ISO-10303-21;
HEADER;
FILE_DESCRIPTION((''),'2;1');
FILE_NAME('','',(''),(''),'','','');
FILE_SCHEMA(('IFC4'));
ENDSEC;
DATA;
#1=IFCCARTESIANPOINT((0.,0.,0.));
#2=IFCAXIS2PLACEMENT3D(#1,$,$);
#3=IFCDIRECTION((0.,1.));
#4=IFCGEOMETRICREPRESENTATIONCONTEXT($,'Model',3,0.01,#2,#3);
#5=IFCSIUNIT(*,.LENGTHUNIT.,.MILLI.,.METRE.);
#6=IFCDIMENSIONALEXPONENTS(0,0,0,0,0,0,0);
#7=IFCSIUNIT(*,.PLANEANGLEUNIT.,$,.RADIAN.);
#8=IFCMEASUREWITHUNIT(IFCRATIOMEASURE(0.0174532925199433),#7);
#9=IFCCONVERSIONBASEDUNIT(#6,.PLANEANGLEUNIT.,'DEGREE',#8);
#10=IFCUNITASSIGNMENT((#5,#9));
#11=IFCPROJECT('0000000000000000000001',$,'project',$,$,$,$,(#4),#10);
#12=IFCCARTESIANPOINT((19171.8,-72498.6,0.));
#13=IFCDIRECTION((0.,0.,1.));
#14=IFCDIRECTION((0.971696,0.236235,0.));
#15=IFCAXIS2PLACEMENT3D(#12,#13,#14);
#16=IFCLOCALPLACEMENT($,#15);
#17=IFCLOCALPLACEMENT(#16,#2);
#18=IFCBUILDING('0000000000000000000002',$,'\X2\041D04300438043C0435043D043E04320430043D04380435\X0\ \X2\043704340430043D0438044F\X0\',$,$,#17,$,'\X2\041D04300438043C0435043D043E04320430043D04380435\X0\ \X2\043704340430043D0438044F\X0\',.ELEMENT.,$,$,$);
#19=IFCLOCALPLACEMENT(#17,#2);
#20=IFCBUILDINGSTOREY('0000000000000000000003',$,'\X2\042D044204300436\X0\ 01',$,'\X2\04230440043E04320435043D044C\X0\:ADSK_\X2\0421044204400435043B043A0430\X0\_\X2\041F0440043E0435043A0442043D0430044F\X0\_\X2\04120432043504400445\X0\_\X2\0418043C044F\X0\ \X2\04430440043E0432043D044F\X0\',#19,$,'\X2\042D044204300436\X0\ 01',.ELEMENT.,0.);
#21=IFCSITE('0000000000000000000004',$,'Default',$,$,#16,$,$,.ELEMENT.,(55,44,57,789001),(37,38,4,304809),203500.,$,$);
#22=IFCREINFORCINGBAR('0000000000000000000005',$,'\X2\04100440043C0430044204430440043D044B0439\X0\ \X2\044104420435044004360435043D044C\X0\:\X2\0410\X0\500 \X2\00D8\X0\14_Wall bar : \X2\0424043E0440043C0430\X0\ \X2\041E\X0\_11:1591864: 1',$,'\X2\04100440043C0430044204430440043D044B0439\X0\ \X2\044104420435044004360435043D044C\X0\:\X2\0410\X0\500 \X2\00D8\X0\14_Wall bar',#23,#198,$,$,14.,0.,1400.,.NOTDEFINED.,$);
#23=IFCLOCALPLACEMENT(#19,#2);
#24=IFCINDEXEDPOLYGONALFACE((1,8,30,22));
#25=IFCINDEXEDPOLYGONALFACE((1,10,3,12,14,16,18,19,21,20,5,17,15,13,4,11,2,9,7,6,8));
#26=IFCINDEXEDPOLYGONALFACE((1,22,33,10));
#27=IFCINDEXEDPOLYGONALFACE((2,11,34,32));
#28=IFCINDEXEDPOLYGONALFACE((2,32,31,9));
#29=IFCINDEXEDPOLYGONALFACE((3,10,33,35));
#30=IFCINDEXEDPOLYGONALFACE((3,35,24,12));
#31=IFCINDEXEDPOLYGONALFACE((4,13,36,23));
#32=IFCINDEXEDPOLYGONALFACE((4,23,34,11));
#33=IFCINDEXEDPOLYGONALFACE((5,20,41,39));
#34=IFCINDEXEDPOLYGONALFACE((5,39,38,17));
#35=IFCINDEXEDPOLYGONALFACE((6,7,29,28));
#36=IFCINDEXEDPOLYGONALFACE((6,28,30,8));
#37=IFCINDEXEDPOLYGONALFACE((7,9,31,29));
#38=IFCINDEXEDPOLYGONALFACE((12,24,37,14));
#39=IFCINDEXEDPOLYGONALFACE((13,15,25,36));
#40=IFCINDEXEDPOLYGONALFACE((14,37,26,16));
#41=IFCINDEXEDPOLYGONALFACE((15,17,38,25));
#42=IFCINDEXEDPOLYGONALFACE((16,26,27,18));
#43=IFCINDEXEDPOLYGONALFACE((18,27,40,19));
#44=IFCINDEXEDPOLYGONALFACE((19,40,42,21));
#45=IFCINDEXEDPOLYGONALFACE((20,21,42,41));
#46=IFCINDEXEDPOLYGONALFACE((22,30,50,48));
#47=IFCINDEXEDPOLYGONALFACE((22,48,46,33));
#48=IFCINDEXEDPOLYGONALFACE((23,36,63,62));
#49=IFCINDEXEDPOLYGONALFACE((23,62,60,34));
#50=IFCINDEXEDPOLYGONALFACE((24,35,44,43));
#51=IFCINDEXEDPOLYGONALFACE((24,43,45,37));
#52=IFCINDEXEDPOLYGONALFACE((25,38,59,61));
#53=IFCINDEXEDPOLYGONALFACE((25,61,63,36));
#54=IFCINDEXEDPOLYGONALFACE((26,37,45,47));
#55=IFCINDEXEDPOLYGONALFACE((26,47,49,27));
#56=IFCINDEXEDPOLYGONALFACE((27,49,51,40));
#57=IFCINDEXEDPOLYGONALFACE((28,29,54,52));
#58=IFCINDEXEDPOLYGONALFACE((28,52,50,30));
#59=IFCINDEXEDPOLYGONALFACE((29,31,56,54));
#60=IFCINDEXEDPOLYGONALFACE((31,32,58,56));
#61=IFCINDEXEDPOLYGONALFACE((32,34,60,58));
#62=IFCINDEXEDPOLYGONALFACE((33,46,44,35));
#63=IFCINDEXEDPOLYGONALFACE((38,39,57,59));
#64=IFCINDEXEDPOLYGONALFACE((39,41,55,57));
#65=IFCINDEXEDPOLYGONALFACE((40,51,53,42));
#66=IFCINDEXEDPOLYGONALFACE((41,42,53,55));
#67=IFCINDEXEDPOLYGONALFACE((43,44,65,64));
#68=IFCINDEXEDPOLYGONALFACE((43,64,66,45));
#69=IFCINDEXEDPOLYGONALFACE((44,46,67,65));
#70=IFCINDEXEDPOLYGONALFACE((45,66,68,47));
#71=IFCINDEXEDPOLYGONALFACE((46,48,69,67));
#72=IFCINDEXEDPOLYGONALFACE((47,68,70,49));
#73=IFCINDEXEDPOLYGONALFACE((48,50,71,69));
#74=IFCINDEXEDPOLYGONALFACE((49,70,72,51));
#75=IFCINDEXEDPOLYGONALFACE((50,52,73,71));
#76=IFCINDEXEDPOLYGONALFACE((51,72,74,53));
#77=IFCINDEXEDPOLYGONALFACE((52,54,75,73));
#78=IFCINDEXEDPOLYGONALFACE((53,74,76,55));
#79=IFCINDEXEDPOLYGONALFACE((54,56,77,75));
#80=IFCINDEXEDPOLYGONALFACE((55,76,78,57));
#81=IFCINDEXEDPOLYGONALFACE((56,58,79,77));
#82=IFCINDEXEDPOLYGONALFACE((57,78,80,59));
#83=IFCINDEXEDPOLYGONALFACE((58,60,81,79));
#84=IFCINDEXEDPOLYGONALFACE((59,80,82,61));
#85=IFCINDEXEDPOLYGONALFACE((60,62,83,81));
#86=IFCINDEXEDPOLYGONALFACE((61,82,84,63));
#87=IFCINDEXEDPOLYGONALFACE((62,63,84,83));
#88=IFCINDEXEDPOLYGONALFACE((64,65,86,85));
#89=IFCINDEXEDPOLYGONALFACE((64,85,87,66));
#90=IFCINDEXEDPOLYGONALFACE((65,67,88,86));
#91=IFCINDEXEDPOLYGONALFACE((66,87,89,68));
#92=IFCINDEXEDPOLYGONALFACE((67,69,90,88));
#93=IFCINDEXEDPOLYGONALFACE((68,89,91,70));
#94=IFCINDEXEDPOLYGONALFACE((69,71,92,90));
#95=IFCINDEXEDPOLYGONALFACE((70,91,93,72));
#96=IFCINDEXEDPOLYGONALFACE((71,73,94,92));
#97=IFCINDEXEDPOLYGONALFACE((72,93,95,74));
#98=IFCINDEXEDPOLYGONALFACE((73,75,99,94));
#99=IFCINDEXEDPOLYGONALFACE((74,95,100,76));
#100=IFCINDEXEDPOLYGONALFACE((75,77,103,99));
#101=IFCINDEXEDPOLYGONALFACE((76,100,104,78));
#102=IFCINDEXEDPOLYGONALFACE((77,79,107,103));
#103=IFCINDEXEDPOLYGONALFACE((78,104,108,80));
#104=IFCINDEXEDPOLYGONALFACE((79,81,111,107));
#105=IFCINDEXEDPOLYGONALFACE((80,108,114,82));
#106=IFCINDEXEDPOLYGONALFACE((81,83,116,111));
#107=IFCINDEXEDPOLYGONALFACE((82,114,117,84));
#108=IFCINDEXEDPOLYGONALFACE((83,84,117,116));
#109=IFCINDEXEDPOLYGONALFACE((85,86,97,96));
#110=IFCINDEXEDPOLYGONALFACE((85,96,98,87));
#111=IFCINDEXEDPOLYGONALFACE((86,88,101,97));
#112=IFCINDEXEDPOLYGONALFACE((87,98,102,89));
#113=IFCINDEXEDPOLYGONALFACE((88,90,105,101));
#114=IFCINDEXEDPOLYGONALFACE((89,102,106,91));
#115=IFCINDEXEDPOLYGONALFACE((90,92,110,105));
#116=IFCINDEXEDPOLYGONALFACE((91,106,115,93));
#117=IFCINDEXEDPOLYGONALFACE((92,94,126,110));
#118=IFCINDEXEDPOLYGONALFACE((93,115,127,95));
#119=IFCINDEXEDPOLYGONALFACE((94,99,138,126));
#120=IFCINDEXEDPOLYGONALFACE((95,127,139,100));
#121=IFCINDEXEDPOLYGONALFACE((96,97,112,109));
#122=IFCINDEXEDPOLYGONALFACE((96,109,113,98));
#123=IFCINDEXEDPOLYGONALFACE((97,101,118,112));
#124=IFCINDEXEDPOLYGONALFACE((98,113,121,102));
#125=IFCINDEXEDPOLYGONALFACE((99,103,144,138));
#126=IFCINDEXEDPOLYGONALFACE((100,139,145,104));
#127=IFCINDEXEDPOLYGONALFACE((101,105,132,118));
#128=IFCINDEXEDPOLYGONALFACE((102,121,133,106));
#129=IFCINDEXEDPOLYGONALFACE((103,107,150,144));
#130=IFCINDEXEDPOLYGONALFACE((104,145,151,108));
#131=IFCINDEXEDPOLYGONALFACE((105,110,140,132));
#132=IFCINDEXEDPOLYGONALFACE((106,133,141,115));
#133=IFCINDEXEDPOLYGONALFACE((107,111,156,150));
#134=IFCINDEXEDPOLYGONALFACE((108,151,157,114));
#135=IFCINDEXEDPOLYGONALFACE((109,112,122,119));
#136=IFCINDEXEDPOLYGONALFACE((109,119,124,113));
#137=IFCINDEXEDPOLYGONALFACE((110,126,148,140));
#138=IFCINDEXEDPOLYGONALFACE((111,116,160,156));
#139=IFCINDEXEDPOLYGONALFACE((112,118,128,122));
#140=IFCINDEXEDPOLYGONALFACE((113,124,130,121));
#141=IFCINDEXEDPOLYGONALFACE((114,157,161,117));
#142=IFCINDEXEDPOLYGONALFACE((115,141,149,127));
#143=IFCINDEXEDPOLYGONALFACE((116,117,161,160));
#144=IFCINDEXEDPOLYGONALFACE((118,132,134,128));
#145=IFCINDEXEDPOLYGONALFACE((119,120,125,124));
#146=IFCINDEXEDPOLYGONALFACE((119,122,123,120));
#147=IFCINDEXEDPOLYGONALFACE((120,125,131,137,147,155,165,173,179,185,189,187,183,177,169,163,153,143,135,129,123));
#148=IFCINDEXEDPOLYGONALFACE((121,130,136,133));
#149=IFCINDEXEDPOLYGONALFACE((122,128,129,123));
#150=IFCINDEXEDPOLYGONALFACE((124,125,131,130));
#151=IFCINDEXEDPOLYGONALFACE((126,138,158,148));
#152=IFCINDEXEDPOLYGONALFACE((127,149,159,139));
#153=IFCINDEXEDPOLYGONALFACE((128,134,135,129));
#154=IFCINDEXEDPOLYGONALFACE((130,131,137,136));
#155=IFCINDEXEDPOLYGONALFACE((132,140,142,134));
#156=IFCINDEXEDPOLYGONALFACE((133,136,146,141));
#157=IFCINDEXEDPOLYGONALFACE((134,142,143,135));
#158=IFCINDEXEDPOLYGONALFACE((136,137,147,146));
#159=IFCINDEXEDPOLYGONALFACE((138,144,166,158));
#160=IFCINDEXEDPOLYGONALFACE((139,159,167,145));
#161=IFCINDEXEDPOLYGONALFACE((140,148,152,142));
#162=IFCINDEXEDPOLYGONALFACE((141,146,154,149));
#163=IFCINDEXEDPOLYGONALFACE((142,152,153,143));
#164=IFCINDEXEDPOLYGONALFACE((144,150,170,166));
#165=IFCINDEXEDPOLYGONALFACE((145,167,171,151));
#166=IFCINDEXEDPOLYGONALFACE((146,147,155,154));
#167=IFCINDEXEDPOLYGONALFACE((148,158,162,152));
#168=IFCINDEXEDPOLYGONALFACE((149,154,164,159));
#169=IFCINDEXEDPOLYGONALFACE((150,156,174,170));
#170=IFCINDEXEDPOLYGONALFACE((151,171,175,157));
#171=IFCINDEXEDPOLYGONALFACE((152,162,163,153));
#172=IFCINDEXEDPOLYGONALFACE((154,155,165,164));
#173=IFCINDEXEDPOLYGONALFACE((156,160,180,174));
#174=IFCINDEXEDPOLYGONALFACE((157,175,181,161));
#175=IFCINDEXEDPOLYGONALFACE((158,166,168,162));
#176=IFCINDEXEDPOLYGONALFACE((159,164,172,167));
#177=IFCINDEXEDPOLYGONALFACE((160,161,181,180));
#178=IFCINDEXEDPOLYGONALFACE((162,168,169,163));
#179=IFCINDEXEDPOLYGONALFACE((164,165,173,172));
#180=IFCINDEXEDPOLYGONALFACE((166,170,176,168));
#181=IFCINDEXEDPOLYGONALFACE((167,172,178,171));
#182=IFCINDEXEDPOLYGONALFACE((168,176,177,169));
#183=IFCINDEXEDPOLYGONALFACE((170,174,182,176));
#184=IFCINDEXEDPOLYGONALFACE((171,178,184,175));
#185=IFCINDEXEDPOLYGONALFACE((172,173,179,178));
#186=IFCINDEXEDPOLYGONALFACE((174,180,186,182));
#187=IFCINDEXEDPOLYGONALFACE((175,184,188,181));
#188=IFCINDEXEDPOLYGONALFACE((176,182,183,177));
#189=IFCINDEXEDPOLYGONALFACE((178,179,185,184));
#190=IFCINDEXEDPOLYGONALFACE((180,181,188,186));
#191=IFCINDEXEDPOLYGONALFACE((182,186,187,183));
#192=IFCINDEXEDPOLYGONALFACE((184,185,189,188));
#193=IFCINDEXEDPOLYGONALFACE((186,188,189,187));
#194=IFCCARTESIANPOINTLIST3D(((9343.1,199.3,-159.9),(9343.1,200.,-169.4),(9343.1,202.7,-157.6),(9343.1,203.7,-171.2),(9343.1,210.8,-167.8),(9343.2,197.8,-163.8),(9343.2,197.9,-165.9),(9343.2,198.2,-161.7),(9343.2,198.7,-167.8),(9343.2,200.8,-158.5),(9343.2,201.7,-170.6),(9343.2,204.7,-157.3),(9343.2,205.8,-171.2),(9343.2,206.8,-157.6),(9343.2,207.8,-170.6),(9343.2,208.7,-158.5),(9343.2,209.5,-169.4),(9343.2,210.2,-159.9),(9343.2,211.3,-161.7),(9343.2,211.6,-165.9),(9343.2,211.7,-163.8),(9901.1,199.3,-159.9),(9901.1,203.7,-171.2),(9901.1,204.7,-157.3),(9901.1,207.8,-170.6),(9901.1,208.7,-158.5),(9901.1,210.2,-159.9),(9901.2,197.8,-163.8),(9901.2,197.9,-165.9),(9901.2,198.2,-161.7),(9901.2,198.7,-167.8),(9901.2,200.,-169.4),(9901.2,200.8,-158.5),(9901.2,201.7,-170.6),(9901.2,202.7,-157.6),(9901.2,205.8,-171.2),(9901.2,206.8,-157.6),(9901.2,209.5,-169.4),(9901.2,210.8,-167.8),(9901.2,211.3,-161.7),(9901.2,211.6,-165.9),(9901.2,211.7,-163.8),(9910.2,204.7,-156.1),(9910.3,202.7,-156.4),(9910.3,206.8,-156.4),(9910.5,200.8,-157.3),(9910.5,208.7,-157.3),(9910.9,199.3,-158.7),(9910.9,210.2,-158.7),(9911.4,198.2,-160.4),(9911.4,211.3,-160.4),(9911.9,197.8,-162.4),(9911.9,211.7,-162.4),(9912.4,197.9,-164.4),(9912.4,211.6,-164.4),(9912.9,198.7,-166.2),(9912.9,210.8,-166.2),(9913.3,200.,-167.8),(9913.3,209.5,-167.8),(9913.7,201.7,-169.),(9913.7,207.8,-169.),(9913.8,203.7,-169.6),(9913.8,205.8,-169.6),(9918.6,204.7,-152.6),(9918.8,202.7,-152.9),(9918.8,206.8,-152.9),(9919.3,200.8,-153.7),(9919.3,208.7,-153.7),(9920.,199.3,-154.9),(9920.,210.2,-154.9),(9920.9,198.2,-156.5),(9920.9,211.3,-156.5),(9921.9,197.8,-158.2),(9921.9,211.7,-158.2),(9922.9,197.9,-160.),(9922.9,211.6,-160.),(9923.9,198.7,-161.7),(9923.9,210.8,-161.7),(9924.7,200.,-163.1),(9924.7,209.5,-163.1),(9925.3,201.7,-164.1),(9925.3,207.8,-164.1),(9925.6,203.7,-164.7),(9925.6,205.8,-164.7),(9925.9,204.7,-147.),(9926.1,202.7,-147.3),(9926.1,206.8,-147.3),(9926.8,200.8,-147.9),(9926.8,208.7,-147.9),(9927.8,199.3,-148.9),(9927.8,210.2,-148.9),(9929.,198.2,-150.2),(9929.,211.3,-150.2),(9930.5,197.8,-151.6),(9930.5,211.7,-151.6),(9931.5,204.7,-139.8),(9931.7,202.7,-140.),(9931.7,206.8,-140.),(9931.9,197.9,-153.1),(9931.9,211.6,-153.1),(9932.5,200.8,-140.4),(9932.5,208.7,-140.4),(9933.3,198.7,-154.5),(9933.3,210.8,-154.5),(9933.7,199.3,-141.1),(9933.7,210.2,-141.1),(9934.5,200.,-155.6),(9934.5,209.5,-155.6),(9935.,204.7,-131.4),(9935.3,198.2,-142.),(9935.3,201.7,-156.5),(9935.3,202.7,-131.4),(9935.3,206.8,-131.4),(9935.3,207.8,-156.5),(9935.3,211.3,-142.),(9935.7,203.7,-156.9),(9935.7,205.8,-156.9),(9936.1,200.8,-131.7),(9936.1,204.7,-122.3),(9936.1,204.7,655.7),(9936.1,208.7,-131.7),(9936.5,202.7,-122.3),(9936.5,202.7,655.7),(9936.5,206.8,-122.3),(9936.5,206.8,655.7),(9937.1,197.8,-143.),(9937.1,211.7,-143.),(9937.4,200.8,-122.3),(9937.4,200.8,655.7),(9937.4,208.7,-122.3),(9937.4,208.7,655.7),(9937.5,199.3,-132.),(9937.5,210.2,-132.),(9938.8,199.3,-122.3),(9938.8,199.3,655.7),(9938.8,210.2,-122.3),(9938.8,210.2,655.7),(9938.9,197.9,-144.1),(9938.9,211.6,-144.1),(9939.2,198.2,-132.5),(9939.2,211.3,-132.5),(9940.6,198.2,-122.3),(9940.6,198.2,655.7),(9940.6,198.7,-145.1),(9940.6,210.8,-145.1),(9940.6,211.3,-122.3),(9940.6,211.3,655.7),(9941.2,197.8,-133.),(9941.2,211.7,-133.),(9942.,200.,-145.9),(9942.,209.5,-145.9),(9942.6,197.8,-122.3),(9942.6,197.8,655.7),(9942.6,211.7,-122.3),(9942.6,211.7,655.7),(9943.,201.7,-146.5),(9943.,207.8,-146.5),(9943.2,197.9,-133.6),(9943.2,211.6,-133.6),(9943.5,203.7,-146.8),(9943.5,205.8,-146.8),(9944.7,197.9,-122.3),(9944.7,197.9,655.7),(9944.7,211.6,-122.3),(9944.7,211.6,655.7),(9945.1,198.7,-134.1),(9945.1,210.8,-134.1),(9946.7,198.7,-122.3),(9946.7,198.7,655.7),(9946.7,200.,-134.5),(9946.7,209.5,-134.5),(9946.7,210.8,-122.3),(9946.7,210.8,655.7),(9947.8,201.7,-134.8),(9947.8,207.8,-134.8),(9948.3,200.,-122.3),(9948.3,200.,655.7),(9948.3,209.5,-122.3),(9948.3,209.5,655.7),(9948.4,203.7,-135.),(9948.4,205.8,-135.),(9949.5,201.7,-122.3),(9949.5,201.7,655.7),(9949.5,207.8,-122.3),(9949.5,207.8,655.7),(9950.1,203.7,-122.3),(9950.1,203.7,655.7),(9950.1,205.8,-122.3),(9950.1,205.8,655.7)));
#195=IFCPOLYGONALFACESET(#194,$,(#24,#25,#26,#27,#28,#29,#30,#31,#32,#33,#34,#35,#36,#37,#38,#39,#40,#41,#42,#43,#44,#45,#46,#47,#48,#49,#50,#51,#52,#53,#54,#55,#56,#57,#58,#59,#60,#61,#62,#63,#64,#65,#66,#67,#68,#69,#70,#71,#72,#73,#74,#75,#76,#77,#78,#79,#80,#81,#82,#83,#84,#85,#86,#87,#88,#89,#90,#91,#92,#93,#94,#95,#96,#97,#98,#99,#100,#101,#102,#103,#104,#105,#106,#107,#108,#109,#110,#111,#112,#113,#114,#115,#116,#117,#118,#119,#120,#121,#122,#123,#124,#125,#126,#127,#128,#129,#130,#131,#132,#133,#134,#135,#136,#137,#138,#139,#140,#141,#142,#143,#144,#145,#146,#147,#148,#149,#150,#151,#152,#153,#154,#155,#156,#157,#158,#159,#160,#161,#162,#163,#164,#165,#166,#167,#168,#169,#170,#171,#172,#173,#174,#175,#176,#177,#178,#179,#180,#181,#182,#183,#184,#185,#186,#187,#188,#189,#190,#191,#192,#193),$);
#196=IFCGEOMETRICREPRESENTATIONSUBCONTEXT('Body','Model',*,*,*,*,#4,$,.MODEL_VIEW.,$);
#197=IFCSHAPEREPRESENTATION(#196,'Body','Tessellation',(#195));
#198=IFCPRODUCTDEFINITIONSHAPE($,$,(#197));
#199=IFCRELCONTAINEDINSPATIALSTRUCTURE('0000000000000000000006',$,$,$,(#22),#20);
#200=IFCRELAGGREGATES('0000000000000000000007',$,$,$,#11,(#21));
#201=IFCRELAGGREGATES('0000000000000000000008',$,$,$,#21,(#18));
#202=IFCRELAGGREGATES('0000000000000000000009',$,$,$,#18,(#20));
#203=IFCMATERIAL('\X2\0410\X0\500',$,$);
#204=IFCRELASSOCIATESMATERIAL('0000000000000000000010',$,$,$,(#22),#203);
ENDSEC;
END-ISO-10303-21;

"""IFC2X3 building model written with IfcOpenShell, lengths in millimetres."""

from ifc_helpers import new_model, entity, si_unit, converted_unit, direction, frame, origin, place, context, subcontext, project, spatial, material, element, save


model = new_model("IFC2X3")

# Units and contexts
model_context = context("Model", 3, precision=0.01, world=origin(), true_north=direction((0.0, 1.0)))
body_context = subcontext(model_context, "Body", "Model", "MODEL_VIEW")
ifc_project = project(units=[si_unit("LENGTHUNIT", "METRE", prefix="MILLI"), converted_unit("PLANEANGLEUNIT", "DEGREE", entity("IfcRatioMeasure", 0.0174532925199433), si_unit("PLANEANGLEUNIT", "RADIAN"), dimensions=[0, 0, 0, 0, 0, 0, 0])], contexts=[model_context])

# Site, building, storey
site_placement = place(None, frame((19171.8, -72498.6, 0.0), z_axis=(0.0, 0.0, 1.0), x_axis=(0.971696, 0.236235, 0.0)))
site = spatial("IfcSite", under=ifc_project, at=site_placement, Name="Default", CompositionType="ELEMENT", RefLatitude=(55, 44, 57, 789001), RefLongitude=(37, 38, 4, 304809), RefElevation=203500.0)
building_placement = place(site_placement, origin())
building = spatial("IfcBuilding", under=site, at=building_placement, Name="Наименование здания", LongName="Наименование здания", CompositionType="ELEMENT")
storey_placement = place(building_placement, origin())
storey = spatial("IfcBuildingStorey", under=building, at=storey_placement, Name="Этаж 01", ObjectType="Уровень:ADSK_Стрелка_Проектная_Вверх_Имя уровня", LongName="Этаж 01", CompositionType="ELEMENT", Elevation=0.0)

# Reinforcing bar
ifc_material = material(Name="А500")
placement = place(storey_placement, origin())
element("IfcReinforcingBar", 1, at=placement, inside=storey, material=ifc_material, Name="Арматурный стержень:А500 Ø14_Wall bar : Форма О_11:1591864: 1", ObjectType="Арматурный стержень:А500 Ø14_Wall bar", BarLength=1400.0, BarRole="NOTDEFINED", CrossSectionArea=0.0, NominalDiameter=14.0, context=body_context, shape_type="AdvancedSweptSolid", body=[
    entity("IfcSweptDiskSolid", entity("IfcCompositeCurve", [entity("IfcCompositeCurveSegment", "CONTINUOUS", True, entity("IfcPolyline", [entity("IfcCartesianPoint", [9943.1, 204.7, 655.7]), entity("IfcCartesianPoint", [9943.1, 204.7, -122.3])])), entity("IfcCompositeCurveSegment", "CONTINUOUS", True, entity("IfcTrimmedCurve", entity("IfcCircle", entity("IfcAxis2Placement3D", entity("IfcCartesianPoint", [9901.1, 204.7, -122.3]), entity("IfcDirection", [0.0, 1.0, 0.0]), entity("IfcDirection", [0.0, 0.0, -1.0])), 42.0), [entity("IfcParameterValue", 270.0)], [entity("IfcParameterValue", 360.0)], True, "PARAMETER")), entity("IfcCompositeCurveSegment", "CONTINUOUS", True, entity("IfcPolyline", [entity("IfcCartesianPoint", [9901.1, 204.7, -164.3]), entity("IfcCartesianPoint", [9343.1, 204.7, -164.3])]))], False), 7.0, None, 0.0, 92.0),
])

save(model, "model.ifc")
